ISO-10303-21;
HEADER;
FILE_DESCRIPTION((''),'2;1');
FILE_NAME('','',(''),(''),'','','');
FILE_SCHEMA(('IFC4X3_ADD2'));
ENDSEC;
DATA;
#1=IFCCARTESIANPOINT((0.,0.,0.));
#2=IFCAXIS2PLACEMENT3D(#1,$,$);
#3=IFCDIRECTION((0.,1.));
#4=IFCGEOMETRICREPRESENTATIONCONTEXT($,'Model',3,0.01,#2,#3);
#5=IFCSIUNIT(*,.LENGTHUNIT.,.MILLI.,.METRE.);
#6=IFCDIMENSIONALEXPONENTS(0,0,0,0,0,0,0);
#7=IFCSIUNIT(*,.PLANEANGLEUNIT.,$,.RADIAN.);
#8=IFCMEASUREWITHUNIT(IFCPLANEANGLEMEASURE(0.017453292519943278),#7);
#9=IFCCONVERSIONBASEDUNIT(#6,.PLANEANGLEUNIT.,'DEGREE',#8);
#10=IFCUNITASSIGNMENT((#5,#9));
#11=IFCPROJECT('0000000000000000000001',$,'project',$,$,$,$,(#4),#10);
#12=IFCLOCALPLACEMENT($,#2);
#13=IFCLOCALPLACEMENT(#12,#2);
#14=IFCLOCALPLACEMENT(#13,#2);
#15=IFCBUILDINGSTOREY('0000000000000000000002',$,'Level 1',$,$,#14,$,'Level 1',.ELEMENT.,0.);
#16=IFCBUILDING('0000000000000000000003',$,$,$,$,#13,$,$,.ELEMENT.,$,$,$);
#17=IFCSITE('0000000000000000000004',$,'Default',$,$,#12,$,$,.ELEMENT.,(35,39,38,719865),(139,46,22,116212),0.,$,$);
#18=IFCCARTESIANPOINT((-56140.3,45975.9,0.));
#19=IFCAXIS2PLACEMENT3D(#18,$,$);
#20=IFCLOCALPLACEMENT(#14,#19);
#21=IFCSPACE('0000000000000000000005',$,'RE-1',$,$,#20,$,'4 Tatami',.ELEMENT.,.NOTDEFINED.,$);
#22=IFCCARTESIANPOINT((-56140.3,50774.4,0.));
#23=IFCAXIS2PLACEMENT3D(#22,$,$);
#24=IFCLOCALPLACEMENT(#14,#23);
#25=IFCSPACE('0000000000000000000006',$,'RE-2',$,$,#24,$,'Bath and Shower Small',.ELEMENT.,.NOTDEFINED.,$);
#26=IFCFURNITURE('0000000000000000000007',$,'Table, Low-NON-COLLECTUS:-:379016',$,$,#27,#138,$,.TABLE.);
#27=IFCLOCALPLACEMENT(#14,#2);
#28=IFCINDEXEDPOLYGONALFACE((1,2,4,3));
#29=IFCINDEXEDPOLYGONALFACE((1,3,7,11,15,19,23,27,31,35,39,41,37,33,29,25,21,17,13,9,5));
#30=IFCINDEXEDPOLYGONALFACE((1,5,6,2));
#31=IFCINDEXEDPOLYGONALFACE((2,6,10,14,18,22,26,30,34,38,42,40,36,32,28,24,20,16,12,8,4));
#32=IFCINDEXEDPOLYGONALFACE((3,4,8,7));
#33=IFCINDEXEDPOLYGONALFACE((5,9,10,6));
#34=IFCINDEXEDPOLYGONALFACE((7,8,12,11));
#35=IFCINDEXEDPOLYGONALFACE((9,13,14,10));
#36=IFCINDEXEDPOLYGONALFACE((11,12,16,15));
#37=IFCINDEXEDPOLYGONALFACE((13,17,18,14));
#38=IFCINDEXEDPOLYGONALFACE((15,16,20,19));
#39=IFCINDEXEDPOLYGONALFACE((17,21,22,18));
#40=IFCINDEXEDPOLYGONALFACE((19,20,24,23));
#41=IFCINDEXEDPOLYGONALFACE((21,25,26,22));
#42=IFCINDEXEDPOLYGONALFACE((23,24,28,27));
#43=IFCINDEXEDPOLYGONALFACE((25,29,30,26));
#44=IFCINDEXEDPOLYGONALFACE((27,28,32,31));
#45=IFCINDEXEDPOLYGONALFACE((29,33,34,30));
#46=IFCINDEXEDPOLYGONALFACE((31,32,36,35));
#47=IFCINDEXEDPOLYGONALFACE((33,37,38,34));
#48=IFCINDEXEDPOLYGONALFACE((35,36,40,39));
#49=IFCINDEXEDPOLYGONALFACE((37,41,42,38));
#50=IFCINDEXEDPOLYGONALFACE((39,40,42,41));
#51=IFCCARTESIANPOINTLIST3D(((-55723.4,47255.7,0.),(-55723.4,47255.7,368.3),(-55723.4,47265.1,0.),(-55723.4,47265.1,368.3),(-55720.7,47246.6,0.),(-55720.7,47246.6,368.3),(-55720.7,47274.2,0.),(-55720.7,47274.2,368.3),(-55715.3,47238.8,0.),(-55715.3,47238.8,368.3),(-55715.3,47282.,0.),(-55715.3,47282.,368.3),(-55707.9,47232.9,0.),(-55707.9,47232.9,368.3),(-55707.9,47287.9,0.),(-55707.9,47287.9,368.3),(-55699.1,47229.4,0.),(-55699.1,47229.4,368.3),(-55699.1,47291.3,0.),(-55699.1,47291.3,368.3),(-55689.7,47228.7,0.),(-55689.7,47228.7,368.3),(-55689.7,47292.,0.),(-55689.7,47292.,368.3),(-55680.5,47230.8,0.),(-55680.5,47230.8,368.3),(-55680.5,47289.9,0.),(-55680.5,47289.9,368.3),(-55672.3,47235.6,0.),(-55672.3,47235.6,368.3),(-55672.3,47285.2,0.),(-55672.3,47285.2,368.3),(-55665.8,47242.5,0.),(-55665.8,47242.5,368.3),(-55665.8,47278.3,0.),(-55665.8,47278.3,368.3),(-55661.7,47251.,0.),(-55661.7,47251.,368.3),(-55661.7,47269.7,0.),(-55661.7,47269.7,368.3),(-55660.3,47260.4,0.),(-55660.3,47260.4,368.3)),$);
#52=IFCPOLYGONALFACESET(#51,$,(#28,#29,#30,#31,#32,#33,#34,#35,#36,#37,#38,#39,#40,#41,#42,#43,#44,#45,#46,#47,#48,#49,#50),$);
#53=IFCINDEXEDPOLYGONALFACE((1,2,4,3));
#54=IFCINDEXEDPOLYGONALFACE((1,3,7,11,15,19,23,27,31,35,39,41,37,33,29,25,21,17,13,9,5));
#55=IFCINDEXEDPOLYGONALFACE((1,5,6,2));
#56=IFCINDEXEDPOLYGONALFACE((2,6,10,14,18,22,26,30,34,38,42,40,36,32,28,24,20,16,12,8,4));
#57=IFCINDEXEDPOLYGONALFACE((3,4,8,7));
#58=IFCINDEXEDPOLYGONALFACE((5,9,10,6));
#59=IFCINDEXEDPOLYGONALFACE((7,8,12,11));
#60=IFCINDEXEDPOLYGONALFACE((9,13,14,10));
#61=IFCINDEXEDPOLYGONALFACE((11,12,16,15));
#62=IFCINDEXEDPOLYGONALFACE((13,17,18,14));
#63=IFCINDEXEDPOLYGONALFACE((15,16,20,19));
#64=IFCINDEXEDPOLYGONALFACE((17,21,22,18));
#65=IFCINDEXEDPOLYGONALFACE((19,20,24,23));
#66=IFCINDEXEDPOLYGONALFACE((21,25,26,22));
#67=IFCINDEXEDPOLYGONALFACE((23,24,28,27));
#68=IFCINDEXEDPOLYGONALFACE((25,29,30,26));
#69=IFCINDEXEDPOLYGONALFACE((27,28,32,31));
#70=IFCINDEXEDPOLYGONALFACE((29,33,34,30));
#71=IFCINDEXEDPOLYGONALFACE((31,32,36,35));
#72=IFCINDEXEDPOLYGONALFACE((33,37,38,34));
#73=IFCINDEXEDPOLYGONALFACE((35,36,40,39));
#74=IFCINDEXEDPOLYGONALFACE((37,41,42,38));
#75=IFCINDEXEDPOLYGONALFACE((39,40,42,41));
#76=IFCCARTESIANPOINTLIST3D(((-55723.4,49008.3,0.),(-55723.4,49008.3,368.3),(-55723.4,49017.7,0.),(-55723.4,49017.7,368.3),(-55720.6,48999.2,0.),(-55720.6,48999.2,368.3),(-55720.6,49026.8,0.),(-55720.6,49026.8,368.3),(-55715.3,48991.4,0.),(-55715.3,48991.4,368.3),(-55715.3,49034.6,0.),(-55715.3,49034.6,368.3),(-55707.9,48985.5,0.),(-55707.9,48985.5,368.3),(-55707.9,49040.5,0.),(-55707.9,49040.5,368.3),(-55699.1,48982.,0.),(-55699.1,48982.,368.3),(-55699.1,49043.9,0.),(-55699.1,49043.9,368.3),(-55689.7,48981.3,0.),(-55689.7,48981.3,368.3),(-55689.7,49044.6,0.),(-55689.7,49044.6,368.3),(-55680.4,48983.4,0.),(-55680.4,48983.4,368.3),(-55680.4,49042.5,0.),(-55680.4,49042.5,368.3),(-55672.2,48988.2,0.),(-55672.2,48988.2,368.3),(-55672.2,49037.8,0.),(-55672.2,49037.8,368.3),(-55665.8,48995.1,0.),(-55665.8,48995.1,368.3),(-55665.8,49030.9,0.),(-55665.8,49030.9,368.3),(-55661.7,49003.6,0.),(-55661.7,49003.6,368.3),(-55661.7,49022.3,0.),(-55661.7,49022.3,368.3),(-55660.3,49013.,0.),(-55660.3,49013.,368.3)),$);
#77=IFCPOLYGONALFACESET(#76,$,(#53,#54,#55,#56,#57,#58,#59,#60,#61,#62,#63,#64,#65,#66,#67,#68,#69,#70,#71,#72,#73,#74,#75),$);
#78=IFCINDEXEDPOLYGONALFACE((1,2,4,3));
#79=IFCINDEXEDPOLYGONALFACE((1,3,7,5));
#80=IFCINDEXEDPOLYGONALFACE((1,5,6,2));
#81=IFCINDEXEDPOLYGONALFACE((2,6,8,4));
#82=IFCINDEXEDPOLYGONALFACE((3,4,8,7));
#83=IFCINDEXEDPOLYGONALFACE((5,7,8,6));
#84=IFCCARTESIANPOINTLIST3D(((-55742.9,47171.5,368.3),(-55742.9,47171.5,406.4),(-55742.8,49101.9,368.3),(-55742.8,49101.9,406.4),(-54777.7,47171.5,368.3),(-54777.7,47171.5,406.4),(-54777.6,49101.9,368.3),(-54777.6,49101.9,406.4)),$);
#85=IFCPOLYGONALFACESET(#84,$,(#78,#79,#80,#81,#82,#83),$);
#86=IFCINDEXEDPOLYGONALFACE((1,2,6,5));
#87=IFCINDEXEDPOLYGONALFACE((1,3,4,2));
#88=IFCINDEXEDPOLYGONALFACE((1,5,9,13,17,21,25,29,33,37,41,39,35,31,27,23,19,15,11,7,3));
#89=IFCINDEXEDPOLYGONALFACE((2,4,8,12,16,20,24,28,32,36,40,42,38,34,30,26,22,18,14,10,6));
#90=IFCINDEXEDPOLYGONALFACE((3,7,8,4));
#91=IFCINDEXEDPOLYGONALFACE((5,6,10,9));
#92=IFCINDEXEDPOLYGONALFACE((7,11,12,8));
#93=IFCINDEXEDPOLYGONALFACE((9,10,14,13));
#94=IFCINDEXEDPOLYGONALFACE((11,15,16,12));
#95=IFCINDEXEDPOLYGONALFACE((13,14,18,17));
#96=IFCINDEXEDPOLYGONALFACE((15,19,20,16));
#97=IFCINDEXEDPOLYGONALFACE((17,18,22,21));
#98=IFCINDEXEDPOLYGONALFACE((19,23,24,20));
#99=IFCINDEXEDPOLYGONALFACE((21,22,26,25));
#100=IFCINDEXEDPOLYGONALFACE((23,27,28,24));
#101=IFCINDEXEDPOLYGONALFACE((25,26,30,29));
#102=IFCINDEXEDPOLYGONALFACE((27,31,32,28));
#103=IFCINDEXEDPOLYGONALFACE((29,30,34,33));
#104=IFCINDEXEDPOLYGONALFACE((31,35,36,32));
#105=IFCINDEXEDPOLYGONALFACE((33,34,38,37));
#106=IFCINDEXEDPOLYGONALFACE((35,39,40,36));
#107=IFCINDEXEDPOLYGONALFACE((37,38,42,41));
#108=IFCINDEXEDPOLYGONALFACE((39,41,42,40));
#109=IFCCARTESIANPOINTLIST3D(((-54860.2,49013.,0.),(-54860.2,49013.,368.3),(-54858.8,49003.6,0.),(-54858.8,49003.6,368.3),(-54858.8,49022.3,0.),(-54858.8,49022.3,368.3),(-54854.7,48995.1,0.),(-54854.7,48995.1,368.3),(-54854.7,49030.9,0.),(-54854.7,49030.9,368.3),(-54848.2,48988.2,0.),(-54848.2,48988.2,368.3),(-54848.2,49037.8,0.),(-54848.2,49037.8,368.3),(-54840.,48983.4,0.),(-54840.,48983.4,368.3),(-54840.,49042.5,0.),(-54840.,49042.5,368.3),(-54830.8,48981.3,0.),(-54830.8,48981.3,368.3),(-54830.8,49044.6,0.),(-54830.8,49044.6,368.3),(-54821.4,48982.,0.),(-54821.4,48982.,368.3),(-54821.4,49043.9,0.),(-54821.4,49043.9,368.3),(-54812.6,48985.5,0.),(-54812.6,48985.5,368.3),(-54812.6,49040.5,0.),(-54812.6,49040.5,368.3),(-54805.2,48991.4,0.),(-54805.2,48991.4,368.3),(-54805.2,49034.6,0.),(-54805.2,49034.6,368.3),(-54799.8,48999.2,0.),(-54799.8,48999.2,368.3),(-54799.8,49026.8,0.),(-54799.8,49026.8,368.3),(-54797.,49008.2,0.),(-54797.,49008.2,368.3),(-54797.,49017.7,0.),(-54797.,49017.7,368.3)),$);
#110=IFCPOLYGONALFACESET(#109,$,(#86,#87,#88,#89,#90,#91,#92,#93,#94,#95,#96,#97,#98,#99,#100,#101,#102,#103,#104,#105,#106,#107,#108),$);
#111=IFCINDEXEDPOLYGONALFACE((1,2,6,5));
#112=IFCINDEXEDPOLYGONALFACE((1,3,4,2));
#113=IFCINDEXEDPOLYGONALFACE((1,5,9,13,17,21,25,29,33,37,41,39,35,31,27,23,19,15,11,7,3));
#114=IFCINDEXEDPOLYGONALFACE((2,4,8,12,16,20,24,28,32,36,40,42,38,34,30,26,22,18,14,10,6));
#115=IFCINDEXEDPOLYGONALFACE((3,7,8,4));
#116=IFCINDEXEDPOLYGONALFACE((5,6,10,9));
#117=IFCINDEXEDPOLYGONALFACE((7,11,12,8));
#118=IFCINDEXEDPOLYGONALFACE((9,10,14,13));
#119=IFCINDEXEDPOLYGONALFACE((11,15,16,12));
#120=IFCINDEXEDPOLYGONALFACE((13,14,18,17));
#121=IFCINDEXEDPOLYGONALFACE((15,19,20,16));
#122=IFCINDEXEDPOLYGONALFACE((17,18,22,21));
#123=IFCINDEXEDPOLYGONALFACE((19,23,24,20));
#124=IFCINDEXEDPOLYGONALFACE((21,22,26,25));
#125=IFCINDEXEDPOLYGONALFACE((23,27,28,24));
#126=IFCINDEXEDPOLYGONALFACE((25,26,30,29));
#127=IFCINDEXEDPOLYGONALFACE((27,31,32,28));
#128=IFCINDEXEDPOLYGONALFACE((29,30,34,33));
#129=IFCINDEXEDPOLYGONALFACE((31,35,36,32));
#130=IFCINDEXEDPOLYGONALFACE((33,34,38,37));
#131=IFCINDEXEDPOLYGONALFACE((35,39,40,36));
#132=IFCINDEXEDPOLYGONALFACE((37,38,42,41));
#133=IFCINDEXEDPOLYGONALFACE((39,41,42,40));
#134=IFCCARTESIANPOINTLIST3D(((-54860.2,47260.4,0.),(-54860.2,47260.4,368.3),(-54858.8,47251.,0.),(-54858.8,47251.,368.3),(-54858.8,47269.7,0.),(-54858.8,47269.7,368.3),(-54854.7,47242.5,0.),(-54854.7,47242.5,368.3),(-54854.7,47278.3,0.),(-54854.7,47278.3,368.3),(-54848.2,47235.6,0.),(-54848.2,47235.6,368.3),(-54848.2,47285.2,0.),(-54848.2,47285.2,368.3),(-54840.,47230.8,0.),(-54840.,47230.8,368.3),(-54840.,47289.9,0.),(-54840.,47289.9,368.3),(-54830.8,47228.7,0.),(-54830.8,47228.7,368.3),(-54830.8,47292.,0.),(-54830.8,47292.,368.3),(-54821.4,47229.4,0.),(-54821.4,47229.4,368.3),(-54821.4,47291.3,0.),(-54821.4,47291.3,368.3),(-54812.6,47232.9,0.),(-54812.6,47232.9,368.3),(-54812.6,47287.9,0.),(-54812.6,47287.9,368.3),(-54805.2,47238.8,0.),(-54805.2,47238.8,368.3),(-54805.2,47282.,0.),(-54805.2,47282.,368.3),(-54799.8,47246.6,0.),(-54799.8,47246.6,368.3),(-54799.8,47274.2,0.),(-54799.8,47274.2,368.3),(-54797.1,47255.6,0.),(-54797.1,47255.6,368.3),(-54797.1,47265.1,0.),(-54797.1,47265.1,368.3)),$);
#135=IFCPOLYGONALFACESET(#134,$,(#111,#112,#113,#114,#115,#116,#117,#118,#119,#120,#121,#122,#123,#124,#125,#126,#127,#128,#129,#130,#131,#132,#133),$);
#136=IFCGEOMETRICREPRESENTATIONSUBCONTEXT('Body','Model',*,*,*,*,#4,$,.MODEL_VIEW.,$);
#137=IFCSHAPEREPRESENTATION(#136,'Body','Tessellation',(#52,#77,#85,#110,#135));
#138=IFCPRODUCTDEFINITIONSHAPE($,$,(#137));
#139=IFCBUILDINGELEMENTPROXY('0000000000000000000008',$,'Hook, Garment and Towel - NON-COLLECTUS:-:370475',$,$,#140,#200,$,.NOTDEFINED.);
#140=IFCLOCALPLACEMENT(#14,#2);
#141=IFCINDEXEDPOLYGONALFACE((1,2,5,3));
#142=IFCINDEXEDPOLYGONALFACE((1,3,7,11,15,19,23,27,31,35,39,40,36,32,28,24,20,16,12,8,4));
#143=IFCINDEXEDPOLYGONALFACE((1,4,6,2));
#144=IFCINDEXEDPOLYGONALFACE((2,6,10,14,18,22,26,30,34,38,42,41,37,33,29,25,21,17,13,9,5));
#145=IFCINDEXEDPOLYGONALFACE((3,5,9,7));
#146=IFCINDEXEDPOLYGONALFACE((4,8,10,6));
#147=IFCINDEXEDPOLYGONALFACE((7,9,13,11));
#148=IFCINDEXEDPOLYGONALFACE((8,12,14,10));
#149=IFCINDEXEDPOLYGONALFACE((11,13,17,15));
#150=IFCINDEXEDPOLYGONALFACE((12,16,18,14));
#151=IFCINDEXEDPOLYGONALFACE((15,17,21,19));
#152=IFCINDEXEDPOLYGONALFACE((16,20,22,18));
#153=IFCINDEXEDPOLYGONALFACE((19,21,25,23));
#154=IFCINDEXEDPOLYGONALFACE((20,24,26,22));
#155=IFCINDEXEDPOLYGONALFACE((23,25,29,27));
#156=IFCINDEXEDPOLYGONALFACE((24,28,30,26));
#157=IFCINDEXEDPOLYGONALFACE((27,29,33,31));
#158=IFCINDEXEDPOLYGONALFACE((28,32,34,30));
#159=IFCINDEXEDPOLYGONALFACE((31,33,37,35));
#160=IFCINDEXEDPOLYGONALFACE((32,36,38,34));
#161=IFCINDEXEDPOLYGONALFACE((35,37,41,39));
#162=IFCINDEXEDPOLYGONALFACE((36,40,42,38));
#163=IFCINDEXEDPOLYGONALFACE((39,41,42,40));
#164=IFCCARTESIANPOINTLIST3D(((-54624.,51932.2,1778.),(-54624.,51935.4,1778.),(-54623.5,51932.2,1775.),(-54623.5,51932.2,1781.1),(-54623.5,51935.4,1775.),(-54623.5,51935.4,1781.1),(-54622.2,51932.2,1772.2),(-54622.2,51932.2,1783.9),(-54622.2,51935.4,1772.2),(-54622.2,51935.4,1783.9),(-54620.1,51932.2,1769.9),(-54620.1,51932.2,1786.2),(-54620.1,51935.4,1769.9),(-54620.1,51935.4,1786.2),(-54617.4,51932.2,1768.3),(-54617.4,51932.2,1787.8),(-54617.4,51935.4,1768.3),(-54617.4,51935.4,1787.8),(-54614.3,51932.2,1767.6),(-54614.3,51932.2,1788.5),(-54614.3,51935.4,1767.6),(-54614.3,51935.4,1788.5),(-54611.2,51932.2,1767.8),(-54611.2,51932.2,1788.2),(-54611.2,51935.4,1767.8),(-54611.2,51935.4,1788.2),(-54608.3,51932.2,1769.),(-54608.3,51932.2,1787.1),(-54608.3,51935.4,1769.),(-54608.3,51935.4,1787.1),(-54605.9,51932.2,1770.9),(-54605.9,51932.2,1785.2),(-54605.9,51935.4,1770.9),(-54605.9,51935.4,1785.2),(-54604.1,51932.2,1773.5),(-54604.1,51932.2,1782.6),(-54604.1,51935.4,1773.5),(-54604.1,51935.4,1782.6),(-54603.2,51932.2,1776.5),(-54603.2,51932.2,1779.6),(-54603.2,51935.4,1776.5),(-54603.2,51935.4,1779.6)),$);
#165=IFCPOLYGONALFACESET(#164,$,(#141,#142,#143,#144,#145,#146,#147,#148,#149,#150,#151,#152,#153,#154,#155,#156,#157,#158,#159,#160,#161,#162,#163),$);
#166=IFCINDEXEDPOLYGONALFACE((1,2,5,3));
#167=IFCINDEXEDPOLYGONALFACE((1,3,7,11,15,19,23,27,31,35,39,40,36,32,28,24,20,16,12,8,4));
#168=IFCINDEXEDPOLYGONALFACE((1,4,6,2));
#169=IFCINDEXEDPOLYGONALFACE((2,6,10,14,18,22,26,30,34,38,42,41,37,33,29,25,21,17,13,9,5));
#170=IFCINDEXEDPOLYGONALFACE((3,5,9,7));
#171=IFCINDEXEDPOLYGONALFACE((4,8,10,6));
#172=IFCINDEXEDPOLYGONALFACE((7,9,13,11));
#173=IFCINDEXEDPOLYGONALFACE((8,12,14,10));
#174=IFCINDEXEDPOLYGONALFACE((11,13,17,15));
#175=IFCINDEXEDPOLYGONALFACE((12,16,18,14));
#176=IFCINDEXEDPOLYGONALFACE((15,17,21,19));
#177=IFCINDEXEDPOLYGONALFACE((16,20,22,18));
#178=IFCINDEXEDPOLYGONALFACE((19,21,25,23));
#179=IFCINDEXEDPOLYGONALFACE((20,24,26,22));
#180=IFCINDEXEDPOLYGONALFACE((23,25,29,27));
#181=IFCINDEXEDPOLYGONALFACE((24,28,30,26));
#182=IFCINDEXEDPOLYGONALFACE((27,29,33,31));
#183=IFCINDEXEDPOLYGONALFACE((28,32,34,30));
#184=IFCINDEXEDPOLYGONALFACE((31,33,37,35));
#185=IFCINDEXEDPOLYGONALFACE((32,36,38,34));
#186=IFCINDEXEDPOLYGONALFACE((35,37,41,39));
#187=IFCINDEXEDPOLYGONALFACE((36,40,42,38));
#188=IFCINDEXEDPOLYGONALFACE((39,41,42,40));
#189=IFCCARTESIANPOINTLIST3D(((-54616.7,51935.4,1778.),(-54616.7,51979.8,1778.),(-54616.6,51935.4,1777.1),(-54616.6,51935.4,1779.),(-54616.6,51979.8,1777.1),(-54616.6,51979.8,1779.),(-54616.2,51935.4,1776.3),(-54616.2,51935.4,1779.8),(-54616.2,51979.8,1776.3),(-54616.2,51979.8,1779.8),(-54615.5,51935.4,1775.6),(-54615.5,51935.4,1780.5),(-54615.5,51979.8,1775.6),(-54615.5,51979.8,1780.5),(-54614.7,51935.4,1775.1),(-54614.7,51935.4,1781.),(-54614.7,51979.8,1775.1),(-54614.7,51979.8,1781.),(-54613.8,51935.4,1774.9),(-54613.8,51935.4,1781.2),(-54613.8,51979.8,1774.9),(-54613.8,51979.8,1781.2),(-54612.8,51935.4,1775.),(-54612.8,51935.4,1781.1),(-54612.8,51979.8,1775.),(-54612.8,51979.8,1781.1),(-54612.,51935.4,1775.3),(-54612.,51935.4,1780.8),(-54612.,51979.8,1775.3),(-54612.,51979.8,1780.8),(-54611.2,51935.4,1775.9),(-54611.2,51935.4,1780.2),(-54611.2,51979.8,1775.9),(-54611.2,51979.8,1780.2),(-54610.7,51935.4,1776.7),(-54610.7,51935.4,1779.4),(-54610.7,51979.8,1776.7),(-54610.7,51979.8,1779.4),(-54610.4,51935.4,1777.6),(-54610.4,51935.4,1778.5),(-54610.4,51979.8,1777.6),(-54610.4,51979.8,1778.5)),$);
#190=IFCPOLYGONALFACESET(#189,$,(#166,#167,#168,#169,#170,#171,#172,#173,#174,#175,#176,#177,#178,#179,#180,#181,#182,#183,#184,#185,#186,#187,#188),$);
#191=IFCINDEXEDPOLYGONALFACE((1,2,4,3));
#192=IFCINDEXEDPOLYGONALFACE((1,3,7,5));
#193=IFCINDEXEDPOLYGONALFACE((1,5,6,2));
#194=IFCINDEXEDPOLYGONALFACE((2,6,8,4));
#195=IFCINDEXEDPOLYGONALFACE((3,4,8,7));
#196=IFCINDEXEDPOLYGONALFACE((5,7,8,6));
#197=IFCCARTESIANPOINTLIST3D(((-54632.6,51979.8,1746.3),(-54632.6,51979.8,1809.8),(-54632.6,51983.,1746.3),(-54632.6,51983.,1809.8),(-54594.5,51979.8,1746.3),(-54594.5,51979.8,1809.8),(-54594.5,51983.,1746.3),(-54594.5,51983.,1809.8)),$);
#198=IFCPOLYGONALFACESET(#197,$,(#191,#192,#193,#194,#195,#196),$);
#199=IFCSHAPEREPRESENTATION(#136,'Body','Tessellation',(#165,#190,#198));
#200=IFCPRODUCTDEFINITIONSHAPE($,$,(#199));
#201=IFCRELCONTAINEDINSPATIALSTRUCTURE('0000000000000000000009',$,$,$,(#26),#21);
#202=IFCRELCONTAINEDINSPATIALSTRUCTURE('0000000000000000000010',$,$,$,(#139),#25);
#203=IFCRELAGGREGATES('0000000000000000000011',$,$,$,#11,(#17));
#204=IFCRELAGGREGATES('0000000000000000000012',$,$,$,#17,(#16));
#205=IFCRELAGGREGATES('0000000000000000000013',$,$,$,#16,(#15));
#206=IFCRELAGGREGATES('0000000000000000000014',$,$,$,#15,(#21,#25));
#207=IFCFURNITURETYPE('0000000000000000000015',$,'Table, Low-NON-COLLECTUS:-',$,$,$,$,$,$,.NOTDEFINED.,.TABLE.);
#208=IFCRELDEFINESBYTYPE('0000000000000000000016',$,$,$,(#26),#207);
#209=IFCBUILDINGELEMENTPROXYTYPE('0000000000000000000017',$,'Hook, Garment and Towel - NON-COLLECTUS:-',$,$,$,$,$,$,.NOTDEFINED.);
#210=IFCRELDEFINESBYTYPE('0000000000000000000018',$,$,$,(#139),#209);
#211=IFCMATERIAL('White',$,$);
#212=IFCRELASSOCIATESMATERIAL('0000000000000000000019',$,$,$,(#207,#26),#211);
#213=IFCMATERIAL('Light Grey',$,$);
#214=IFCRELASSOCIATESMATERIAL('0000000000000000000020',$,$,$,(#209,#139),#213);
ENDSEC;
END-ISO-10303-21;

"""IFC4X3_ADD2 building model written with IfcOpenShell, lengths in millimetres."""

from ifc_helpers import new_model, entity, si_unit, converted_unit, direction, frame, frame_2d, origin, origin_2d_with_axis, place, context, subcontext, project, spatial, rectangle, circle, extrude, source, transform, mapped, material, type_object, type_shapes, element, save


model = new_model("IFC4X3_ADD2")

# Units and contexts
model_context = context("Model", 3, precision=0.01, world=origin(), true_north=direction((0.0, 1.0)))
body_context = subcontext(model_context, "Body", "Model", "MODEL_VIEW")
ifc_project = project(units=[si_unit("LENGTHUNIT", "METRE", prefix="MILLI"), converted_unit("PLANEANGLEUNIT", "DEGREE", entity("IfcPlaneAngleMeasure", 0.017453292519943278), si_unit("PLANEANGLEUNIT", "RADIAN"), dimensions=[0, 0, 0, 0, 0, 0, 0])], contexts=[model_context])

# Site, building, storey
site_placement = place(None, origin())
site = spatial("IfcSite", under=ifc_project, at=site_placement, Name="Default", CompositionType="ELEMENT", RefLatitude=(35, 39, 38, 719865), RefLongitude=(139, 46, 22, 116212), RefElevation=0.0)
building_placement = place(site_placement, origin())
building = spatial("IfcBuilding", under=site, at=building_placement, CompositionType="ELEMENT")
storey_placement = place(building_placement, origin())
storey = spatial("IfcBuildingStorey", under=building, at=storey_placement, Name="Level 1", LongName="Level 1", CompositionType="ELEMENT", Elevation=0.0)

# Shared definitions
ifc_material_1 = material(Name="White")

# Shared definitions
space_1_placement = place(storey_placement, frame((-56140.3, 45975.9, 0.0)))
space_1 = spatial("IfcSpace", under=storey, at=space_1_placement, Name="RE-1", LongName="4 Tatami", CompositionType="ELEMENT", PredefinedType="NOTDEFINED")

# Furniture
furniture_type_1 = type_object("IfcFurnitureType", Name="Table, Low-NON-COLLECTUS:-", AssemblyPlace="NOTDEFINED", PredefinedType="TABLE", material=ifc_material_1)
shared_shape_1 = source(origin(), body_context, "Body", "SweptSolid", [
    extrude(circle(Radius=31.8, at=frame_2d((0.0, 0.0), x_axis=(1.0, 0.0))), frame((876.3, -431.8, 0.0), z_axis=(0.0, 0.0, 1.0), x_axis=(0.0, 1.0, 0.0)), (0.0, 0.0, 1.0), 368.3),
    extrude(circle(Radius=31.8, at=origin_2d_with_axis()), frame((-876.3, -431.8, 0.0), z_axis=(0.0, 0.0, 1.0), x_axis=(0.0, 1.0, 0.0)), (0.0, 0.0, 1.0), 368.3),
    extrude(rectangle(XDim=1930.4, YDim=965.2, at=origin_2d_with_axis()), frame((0.0, 0.0, 368.3), z_axis=(0.0, 0.0, 1.0), x_axis=(-1.0, 0.0, 0.0)), (0.0, 0.0, 1.0), 38.1),
    extrude(circle(Radius=31.8, at=origin_2d_with_axis()), frame((-876.3, 431.8, 0.0), z_axis=(0.0, 0.0, 1.0), x_axis=(0.0, -1.0, 0.0)), (0.0, 0.0, 1.0), 368.3),
    extrude(circle(Radius=31.8, at=frame_2d((0.0, 0.0), x_axis=(1.0, 0.0))), frame((876.3, 431.8, 0.0), z_axis=(0.0, 0.0, 1.0), x_axis=(0.0, -1.0, 0.0)), (0.0, 0.0, 1.0), 368.3),
])
type_shapes(furniture_type_1, [shared_shape_1])
furniture_1_placement = place(space_1_placement, frame((880.0, 2160.8, 0.0), z_axis=(0.0, 0.0, 1.0), x_axis=(-0.000004, -1.0, 0.0)))
element("IfcFurniture", 1, at=furniture_1_placement, inside=space_1, type_object=furniture_type_1, material=ifc_material_1, Name="Table, Low-NON-COLLECTUS:-:379016", PredefinedType="TABLE", context=body_context, shape_type="MappedRepresentation", body=[
    mapped(shared_shape_1, transform((0.0, 0.0, 0.0), scale=1.0)),
])

# Shared definitions
space_2_placement = place(storey_placement, frame((-56140.3, 50774.4, 0.0)))
space_2 = spatial("IfcSpace", under=storey, at=space_2_placement, Name="RE-2", LongName="Bath and Shower Small", CompositionType="ELEMENT", PredefinedType="NOTDEFINED")

# Building element proxy
ifc_material_2 = material(Name="Light Grey")
building_element_proxy_type_1 = type_object("IfcBuildingElementProxyType", Name="Hook, Garment and Towel - NON-COLLECTUS:-", PredefinedType="NOTDEFINED", material=ifc_material_2)
shared_shape_2 = source(origin(), body_context, "Body", "SweptSolid", [
    extrude(circle(Radius=10.5, at=frame_2d((0.0, 0.0), x_axis=(1.0, 0.0))), frame((19.1, -50.8, 31.8), z_axis=(0.0, 1.0, 0.0), x_axis=(-1.0, 0.0, 0.0)), (0.0, 0.0, 1.0), 3.2),
    extrude(circle(Radius=3.2, at=frame_2d((0.0, 0.0), x_axis=(1.0, 0.0))), frame((19.1, -47.6, 31.8), z_axis=(0.0, 1.0, 0.0), x_axis=(-1.0, 0.0, 0.0)), (0.0, 0.0, 1.0), 44.5),
    extrude(rectangle(XDim=3.2, YDim=38.1, at=origin_2d_with_axis()), frame((19.1, -1.6, 0.0), z_axis=(0.0, 0.0, 1.0), x_axis=(0.0, 1.0, 0.0)), (0.0, 0.0, 1.0), 63.5),
])
type_shapes(building_element_proxy_type_1, [shared_shape_2])
proxy_1_placement = place(space_2_placement, frame((1507.7, 1208.6, 1746.3)))
element("IfcBuildingElementProxy", 2, at=proxy_1_placement, inside=space_2, type_object=building_element_proxy_type_1, material=ifc_material_2, Name="Hook, Garment and Towel - NON-COLLECTUS:-:370475", PredefinedType="NOTDEFINED", context=body_context, shape_type="MappedRepresentation", body=[
    mapped(shared_shape_2, transform((0.0, 0.0, 0.0), scale=1.0)),
])

save(model, "model.ifc")
